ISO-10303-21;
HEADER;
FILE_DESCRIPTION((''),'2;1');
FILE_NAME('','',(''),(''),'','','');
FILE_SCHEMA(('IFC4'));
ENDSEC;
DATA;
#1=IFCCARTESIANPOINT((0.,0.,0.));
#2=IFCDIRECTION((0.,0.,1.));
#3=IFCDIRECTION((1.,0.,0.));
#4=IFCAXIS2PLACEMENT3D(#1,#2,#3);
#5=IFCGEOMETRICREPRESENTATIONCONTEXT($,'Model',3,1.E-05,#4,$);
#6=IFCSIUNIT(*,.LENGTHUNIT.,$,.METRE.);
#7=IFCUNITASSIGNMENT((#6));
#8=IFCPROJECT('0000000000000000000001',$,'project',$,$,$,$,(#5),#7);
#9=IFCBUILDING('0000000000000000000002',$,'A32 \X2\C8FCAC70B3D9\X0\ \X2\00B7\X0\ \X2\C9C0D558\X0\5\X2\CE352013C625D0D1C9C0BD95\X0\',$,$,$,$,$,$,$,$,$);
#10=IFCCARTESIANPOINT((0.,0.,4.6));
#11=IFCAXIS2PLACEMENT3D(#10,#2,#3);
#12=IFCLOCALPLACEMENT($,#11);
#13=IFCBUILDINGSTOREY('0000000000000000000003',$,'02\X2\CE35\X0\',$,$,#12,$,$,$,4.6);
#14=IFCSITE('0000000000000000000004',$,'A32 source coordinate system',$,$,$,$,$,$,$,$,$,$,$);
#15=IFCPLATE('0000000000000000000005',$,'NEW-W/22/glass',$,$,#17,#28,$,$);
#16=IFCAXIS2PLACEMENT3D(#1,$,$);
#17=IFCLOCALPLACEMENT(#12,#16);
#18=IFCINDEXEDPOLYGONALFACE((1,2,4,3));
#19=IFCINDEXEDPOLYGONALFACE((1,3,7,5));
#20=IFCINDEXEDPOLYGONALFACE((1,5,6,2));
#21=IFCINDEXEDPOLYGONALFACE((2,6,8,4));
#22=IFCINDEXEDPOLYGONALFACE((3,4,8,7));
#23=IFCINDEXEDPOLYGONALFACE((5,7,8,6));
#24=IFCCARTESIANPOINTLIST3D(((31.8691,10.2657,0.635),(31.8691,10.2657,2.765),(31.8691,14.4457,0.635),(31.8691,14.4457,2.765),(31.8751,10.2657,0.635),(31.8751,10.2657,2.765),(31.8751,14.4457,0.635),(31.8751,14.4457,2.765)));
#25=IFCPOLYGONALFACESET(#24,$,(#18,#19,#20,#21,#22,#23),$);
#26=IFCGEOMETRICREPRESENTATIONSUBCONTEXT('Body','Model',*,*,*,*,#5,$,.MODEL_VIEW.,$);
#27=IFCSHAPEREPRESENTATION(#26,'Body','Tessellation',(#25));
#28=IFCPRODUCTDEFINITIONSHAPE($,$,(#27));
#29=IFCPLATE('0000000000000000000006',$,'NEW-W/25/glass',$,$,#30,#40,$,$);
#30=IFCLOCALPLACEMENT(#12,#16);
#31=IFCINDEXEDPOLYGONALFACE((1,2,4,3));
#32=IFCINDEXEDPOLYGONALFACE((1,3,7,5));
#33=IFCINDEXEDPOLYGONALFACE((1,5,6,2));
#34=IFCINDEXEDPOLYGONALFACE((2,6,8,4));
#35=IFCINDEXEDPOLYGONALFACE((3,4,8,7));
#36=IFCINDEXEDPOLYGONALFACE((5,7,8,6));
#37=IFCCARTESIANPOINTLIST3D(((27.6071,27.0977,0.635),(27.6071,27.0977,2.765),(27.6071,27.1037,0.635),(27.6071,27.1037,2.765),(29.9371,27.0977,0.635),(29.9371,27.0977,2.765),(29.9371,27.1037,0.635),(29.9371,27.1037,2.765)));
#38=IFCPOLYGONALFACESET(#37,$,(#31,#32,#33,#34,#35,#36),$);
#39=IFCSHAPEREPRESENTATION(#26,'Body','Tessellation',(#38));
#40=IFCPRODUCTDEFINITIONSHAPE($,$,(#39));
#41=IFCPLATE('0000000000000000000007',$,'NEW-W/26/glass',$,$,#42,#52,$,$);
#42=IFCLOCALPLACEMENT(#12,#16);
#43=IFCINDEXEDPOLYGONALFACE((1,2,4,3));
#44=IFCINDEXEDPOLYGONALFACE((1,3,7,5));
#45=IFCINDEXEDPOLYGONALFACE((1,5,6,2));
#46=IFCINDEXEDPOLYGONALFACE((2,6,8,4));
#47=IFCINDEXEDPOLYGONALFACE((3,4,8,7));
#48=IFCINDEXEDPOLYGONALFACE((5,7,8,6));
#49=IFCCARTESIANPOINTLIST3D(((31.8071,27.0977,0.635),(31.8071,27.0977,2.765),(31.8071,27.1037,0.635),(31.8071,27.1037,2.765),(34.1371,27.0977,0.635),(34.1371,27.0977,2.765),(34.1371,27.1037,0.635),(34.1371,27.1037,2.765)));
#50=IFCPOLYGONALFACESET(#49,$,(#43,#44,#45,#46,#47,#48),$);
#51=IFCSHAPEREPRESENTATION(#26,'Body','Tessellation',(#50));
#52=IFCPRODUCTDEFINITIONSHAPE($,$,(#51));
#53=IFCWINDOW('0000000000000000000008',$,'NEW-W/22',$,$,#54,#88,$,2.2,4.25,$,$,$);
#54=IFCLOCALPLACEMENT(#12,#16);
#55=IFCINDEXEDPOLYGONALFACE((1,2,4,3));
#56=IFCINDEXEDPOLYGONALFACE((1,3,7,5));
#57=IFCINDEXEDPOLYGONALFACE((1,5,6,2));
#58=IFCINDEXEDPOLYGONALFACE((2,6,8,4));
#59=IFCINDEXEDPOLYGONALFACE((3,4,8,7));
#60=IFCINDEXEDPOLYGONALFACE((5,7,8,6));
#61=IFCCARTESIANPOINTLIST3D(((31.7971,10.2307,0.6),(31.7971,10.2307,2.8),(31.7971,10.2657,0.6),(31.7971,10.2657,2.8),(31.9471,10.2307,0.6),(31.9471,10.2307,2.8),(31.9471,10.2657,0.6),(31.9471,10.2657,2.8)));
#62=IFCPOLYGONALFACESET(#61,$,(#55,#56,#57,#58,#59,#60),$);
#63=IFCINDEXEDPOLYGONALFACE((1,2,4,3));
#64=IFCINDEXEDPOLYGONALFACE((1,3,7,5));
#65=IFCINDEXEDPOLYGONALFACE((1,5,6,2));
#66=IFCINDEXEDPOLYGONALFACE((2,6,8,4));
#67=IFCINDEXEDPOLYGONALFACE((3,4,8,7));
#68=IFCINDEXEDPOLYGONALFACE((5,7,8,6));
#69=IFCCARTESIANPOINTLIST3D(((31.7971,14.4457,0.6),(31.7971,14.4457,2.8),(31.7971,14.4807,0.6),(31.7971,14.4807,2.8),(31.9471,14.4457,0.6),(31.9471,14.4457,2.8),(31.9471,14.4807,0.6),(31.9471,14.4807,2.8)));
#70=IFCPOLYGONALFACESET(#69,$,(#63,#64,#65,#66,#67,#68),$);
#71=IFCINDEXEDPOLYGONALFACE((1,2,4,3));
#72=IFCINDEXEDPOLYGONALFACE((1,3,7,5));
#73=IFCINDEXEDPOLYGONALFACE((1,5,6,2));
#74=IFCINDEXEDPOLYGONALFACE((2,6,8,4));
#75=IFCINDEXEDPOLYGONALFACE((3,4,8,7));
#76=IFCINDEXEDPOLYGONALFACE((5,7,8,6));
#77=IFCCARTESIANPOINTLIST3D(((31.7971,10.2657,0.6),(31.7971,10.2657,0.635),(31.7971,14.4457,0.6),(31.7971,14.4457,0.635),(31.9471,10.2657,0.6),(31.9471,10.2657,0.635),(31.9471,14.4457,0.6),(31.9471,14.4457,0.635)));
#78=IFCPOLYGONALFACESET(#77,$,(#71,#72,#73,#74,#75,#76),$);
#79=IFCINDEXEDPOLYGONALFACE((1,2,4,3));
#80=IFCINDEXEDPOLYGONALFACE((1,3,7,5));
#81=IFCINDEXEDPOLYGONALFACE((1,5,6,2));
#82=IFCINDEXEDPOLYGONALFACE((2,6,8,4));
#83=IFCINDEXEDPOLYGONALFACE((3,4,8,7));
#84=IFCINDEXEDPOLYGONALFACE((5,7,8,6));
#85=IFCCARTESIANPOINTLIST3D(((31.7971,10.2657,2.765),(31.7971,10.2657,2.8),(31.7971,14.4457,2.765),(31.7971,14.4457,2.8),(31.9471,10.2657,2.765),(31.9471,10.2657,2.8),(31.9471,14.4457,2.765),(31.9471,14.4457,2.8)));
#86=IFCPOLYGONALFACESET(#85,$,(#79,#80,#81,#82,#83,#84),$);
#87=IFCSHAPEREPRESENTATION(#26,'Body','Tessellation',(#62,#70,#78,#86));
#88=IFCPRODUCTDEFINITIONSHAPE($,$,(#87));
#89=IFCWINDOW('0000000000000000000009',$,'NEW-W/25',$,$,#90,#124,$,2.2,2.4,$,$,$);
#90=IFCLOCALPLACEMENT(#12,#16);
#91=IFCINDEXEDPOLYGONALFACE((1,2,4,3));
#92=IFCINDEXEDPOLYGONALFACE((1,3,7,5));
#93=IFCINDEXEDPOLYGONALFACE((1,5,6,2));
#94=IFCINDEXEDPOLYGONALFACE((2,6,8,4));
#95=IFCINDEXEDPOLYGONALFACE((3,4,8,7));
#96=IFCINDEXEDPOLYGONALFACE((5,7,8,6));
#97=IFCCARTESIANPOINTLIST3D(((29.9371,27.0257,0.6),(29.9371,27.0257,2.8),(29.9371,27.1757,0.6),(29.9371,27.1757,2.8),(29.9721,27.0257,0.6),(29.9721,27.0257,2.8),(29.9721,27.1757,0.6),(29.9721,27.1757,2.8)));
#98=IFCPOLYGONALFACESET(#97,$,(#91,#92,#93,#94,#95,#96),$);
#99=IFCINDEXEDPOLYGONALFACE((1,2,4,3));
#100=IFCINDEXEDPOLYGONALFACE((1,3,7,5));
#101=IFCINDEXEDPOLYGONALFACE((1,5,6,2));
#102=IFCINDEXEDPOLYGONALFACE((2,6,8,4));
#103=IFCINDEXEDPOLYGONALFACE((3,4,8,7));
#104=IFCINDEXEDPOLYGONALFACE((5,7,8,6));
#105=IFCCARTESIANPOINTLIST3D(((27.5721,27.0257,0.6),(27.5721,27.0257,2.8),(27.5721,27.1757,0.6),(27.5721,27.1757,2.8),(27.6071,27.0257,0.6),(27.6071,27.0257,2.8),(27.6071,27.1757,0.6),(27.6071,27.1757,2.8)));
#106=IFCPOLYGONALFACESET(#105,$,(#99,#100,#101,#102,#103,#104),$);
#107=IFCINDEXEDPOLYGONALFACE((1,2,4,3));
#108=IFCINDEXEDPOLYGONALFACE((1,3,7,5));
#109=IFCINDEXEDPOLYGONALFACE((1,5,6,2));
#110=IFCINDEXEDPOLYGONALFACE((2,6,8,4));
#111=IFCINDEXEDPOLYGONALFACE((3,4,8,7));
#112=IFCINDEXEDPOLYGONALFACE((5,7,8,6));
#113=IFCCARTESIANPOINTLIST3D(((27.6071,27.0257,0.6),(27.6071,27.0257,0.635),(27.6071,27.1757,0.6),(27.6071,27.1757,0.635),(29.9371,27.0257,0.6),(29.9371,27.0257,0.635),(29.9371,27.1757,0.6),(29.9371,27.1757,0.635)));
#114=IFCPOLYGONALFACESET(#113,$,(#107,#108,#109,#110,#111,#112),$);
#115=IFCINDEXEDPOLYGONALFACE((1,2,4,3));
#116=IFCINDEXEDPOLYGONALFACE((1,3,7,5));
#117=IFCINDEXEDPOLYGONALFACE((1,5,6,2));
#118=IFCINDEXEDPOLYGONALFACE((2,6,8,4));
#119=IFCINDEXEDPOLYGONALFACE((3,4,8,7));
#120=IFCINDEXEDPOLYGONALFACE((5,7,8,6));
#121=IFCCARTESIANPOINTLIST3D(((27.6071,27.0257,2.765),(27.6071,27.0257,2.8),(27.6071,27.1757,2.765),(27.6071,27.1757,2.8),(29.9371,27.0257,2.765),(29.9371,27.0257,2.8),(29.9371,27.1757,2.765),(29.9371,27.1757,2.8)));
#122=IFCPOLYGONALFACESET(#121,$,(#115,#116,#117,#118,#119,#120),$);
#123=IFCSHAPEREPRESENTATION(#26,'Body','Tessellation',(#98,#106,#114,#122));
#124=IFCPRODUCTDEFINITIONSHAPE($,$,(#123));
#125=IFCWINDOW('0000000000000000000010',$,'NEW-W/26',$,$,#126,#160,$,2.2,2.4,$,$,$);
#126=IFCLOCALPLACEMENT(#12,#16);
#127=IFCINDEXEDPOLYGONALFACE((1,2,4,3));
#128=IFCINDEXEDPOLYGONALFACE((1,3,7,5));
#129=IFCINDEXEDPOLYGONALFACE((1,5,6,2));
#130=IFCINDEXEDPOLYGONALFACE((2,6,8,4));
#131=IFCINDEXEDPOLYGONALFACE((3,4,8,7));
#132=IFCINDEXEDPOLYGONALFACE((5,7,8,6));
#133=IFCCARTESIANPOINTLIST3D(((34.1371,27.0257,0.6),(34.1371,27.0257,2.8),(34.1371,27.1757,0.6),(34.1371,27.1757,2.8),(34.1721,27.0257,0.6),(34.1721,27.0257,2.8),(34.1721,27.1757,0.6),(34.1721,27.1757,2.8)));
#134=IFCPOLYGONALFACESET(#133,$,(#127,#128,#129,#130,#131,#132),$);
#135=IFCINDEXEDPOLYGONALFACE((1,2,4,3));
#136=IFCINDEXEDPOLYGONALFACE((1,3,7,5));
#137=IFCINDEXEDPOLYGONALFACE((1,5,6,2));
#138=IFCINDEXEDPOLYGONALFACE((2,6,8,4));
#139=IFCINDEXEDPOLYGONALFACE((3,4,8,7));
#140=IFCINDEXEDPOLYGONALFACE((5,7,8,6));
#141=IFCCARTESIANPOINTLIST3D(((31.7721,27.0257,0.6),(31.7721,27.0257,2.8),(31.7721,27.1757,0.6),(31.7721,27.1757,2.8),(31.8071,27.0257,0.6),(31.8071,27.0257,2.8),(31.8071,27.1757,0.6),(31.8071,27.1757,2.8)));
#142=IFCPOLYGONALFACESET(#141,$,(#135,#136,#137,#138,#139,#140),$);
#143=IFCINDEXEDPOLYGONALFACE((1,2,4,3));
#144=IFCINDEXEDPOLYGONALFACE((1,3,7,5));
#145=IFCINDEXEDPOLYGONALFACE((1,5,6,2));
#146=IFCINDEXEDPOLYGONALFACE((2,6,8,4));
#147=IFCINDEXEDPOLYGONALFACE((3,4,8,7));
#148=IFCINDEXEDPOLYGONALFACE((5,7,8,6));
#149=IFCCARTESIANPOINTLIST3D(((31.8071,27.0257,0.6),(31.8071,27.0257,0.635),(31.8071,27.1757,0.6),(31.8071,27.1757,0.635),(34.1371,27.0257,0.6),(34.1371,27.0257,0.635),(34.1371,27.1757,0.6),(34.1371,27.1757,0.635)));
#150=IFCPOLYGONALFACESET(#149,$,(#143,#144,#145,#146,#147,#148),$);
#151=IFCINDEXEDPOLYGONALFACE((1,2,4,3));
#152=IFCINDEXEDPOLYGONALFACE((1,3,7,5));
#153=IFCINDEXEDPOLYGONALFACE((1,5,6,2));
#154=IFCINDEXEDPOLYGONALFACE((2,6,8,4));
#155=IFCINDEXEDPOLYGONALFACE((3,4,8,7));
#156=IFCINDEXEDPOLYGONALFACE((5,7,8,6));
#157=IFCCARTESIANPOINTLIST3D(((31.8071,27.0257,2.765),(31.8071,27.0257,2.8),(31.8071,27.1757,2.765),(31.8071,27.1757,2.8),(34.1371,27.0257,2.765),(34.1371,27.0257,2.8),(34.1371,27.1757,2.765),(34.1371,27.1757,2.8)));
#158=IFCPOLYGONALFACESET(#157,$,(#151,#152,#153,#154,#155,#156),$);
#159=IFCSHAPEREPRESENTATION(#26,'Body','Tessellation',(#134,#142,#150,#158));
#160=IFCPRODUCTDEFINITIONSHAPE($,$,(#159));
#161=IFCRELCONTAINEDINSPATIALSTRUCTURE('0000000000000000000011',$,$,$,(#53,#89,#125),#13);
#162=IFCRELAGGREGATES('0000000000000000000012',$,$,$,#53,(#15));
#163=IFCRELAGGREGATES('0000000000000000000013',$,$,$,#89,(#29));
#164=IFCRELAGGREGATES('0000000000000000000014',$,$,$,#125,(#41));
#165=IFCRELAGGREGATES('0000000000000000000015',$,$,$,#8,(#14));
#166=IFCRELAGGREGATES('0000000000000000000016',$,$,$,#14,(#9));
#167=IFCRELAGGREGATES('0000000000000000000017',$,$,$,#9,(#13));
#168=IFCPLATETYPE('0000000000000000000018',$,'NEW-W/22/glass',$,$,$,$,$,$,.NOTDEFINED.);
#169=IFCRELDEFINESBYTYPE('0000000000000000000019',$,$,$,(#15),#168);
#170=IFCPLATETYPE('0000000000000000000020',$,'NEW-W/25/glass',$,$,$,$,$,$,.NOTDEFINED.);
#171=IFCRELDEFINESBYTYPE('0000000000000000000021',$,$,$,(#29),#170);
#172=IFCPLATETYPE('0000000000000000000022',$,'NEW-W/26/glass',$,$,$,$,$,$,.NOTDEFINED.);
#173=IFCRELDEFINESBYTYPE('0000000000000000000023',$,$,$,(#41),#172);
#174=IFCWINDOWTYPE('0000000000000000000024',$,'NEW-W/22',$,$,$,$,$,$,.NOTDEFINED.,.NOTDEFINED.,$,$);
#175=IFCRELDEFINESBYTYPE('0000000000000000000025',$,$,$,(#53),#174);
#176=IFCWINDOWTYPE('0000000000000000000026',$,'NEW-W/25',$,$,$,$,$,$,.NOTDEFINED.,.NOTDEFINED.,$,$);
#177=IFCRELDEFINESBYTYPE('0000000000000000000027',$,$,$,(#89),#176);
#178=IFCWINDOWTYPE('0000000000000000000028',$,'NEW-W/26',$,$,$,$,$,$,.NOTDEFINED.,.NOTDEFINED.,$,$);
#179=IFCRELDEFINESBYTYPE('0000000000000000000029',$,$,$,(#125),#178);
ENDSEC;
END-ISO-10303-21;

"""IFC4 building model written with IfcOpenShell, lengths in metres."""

from ifc_helpers import new_model, si_unit, frame, origin, origin_with_axes, place, context, subcontext, project, spatial, polyline, outline, extrude, source, transform, mapped, type_object, type_shapes, element, aggregate, save


model = new_model("IFC4")

# Units and contexts
model_context = context("Model", 3, precision=1e-05, world=origin_with_axes())
body_context = subcontext(model_context, "Body", "Model", "MODEL_VIEW")
ifc_project = project(units=[si_unit("LENGTHUNIT", "METRE")], contexts=[model_context])

# Plates
plate_type_1 = type_object("IfcPlateType", Name="NEW-W/22/glass", PredefinedType="NOTDEFINED")
shared_shape_1 = source(origin(), body_context, "Body", "SweptSolid", [
    extrude(outline(polyline([(31.8751, 10.2657), (31.8691, 10.2657), (31.8691, 14.4457), (31.8751, 14.4457), (31.8751, 10.2657)])), frame((0.0, 0.0, 0.635)), (0.0, 0.0, 1.0), 2.13),
])
type_shapes(plate_type_1, [shared_shape_1])
storey_placement = place(None, frame((0.0, 0.0, 4.6), z_axis=(0.0, 0.0, 1.0), x_axis=(1.0, 0.0, 0.0)))
window_1_placement = place(storey_placement, origin_with_axes())
plate_1_placement = place(window_1_placement, origin_with_axes())
plate_1 = element("IfcPlate", 1, at=plate_1_placement, type_object=plate_type_1, Name="NEW-W/22/glass", context=body_context, shape_type="MappedRepresentation", body=[
    mapped(shared_shape_1, transform((0.0, 0.0, 0.0), scale=1.0)),
])
plate_type_2 = type_object("IfcPlateType", Name="NEW-W/25/glass", PredefinedType="NOTDEFINED")
shared_shape_2 = source(origin(), body_context, "Body", "SweptSolid", [
    extrude(outline(polyline([(29.9371, 27.0977), (27.6071, 27.0977), (27.6071, 27.1037), (29.9371, 27.1037), (29.9371, 27.0977)])), frame((0.0, 0.0, 0.635)), (0.0, 0.0, 1.0), 2.13),
])
type_shapes(plate_type_2, [shared_shape_2])
window_2_placement = place(storey_placement, origin_with_axes())
plate_2_placement = place(window_2_placement, origin_with_axes())
plate_2 = element("IfcPlate", 2, at=plate_2_placement, type_object=plate_type_2, Name="NEW-W/25/glass", context=body_context, shape_type="MappedRepresentation", body=[
    mapped(shared_shape_2, transform((0.0, 0.0, 0.0), scale=1.0)),
])
plate_type_3 = type_object("IfcPlateType", Name="NEW-W/26/glass", PredefinedType="NOTDEFINED")
shared_shape_3 = source(origin(), body_context, "Body", "SweptSolid", [
    extrude(outline(polyline([(34.1371, 27.0977), (31.8071, 27.0977), (31.8071, 27.1037), (34.1371, 27.1037), (34.1371, 27.0977)])), frame((0.0, 0.0, 0.635)), (0.0, 0.0, 1.0), 2.13),
])
type_shapes(plate_type_3, [shared_shape_3])
window_3_placement = place(storey_placement, origin_with_axes())
plate_3_placement = place(window_3_placement, origin_with_axes())
plate_3 = element("IfcPlate", 3, at=plate_3_placement, type_object=plate_type_3, Name="NEW-W/26/glass", context=body_context, shape_type="MappedRepresentation", body=[
    mapped(shared_shape_3, transform((0.0, 0.0, 0.0), scale=1.0)),
])

# Site, building, storey
site = spatial("IfcSite", under=ifc_project, Name="A32 source coordinate system")
building = spatial("IfcBuilding", under=site, Name="A32 주거동 · 지하5층–옥탑지붕")
storey = spatial("IfcBuildingStorey", under=building, at=storey_placement, Name="02층", Elevation=4.6)

# Windows
window_type_1 = type_object("IfcWindowType", Name="NEW-W/22", PartitioningType="NOTDEFINED", PredefinedType="NOTDEFINED")
shared_shape_4 = source(origin(), body_context, "Body", "SweptSolid", [
    extrude(outline(polyline([(31.7971, 10.2307), (31.7971, 10.2657), (31.9471, 10.2657), (31.9471, 10.2307), (31.7971, 10.2307)])), frame((0.0, 0.0, 0.6)), (0.0, 0.0, 1.0), 2.2),
    extrude(outline(polyline([(31.7971, 14.4457), (31.7971, 14.4807), (31.9471, 14.4807), (31.9471, 14.4457), (31.7971, 14.4457)])), frame((0.0, 0.0, 0.6)), (0.0, 0.0, 1.0), 2.2),
    extrude(outline(polyline([(31.9471, 10.2657), (31.9471, 14.4457), (31.7971, 14.4457), (31.7971, 10.2657), (31.9471, 10.2657)])), frame((0.0, 0.0, 0.6)), (0.0, 0.0, 1.0), 0.035),
    extrude(outline(polyline([(31.9471, 10.2657), (31.9471, 14.4457), (31.7971, 14.4457), (31.7971, 10.2657), (31.9471, 10.2657)])), frame((0.0, 0.0, 2.765)), (0.0, 0.0, 1.0), 0.035),
])
type_shapes(window_type_1, [shared_shape_4])
window_1 = element("IfcWindow", 4, at=window_1_placement, inside=storey, type_object=window_type_1, Name="NEW-W/22", OverallHeight=2.2, OverallWidth=4.25, context=body_context, shape_type="MappedRepresentation", body=[
    mapped(shared_shape_4, transform((0.0, 0.0, 0.0), scale=1.0)),
])
aggregate(window_1, [plate_1])
window_type_2 = type_object("IfcWindowType", Name="NEW-W/25", PartitioningType="NOTDEFINED", PredefinedType="NOTDEFINED")
shared_shape_5 = source(origin(), body_context, "Body", "SweptSolid", [
    extrude(outline(polyline([(29.9371, 27.0257), (29.9371, 27.1757), (29.9721, 27.1757), (29.9721, 27.0257), (29.9371, 27.0257)])), frame((0.0, 0.0, 0.6)), (0.0, 0.0, 1.0), 2.2),
    extrude(outline(polyline([(27.5721, 27.0257), (27.5721, 27.1757), (27.6071, 27.1757), (27.6071, 27.0257), (27.5721, 27.0257)])), frame((0.0, 0.0, 0.6)), (0.0, 0.0, 1.0), 2.2),
    extrude(outline(polyline([(29.9371, 27.0257), (29.9371, 27.1757), (27.6071, 27.1757), (27.6071, 27.0257), (29.9371, 27.0257)])), frame((0.0, 0.0, 0.6)), (0.0, 0.0, 1.0), 0.035),
    extrude(outline(polyline([(29.9371, 27.0257), (29.9371, 27.1757), (27.6071, 27.1757), (27.6071, 27.0257), (29.9371, 27.0257)])), frame((0.0, 0.0, 2.765)), (0.0, 0.0, 1.0), 0.035),
])
type_shapes(window_type_2, [shared_shape_5])
window_2 = element("IfcWindow", 5, at=window_2_placement, inside=storey, type_object=window_type_2, Name="NEW-W/25", OverallHeight=2.2, OverallWidth=2.4, context=body_context, shape_type="MappedRepresentation", body=[
    mapped(shared_shape_5, transform((0.0, 0.0, 0.0), scale=1.0)),
])
aggregate(window_2, [plate_2])
window_type_3 = type_object("IfcWindowType", Name="NEW-W/26", PartitioningType="NOTDEFINED", PredefinedType="NOTDEFINED")
shared_shape_6 = source(origin(), body_context, "Body", "SweptSolid", [
    extrude(outline(polyline([(34.1371, 27.0257), (34.1371, 27.1757), (34.1721, 27.1757), (34.1721, 27.0257), (34.1371, 27.0257)])), frame((0.0, 0.0, 0.6)), (0.0, 0.0, 1.0), 2.2),
    extrude(outline(polyline([(31.7721, 27.0257), (31.7721, 27.1757), (31.8071, 27.1757), (31.8071, 27.0257), (31.7721, 27.0257)])), frame((0.0, 0.0, 0.6)), (0.0, 0.0, 1.0), 2.2),
    extrude(outline(polyline([(34.1371, 27.0257), (34.1371, 27.1757), (31.8071, 27.1757), (31.8071, 27.0257), (34.1371, 27.0257)])), frame((0.0, 0.0, 0.6)), (0.0, 0.0, 1.0), 0.035),
    extrude(outline(polyline([(34.1371, 27.0257), (34.1371, 27.1757), (31.8071, 27.1757), (31.8071, 27.0257), (34.1371, 27.0257)])), frame((0.0, 0.0, 2.765)), (0.0, 0.0, 1.0), 0.035),
])
type_shapes(window_type_3, [shared_shape_6])
window_3 = element("IfcWindow", 6, at=window_3_placement, inside=storey, type_object=window_type_3, Name="NEW-W/26", OverallHeight=2.2, OverallWidth=2.4, context=body_context, shape_type="MappedRepresentation", body=[
    mapped(shared_shape_6, transform((0.0, 0.0, 0.0), scale=1.0)),
])
aggregate(window_3, [plate_3])

save(model, "model.ifc")
